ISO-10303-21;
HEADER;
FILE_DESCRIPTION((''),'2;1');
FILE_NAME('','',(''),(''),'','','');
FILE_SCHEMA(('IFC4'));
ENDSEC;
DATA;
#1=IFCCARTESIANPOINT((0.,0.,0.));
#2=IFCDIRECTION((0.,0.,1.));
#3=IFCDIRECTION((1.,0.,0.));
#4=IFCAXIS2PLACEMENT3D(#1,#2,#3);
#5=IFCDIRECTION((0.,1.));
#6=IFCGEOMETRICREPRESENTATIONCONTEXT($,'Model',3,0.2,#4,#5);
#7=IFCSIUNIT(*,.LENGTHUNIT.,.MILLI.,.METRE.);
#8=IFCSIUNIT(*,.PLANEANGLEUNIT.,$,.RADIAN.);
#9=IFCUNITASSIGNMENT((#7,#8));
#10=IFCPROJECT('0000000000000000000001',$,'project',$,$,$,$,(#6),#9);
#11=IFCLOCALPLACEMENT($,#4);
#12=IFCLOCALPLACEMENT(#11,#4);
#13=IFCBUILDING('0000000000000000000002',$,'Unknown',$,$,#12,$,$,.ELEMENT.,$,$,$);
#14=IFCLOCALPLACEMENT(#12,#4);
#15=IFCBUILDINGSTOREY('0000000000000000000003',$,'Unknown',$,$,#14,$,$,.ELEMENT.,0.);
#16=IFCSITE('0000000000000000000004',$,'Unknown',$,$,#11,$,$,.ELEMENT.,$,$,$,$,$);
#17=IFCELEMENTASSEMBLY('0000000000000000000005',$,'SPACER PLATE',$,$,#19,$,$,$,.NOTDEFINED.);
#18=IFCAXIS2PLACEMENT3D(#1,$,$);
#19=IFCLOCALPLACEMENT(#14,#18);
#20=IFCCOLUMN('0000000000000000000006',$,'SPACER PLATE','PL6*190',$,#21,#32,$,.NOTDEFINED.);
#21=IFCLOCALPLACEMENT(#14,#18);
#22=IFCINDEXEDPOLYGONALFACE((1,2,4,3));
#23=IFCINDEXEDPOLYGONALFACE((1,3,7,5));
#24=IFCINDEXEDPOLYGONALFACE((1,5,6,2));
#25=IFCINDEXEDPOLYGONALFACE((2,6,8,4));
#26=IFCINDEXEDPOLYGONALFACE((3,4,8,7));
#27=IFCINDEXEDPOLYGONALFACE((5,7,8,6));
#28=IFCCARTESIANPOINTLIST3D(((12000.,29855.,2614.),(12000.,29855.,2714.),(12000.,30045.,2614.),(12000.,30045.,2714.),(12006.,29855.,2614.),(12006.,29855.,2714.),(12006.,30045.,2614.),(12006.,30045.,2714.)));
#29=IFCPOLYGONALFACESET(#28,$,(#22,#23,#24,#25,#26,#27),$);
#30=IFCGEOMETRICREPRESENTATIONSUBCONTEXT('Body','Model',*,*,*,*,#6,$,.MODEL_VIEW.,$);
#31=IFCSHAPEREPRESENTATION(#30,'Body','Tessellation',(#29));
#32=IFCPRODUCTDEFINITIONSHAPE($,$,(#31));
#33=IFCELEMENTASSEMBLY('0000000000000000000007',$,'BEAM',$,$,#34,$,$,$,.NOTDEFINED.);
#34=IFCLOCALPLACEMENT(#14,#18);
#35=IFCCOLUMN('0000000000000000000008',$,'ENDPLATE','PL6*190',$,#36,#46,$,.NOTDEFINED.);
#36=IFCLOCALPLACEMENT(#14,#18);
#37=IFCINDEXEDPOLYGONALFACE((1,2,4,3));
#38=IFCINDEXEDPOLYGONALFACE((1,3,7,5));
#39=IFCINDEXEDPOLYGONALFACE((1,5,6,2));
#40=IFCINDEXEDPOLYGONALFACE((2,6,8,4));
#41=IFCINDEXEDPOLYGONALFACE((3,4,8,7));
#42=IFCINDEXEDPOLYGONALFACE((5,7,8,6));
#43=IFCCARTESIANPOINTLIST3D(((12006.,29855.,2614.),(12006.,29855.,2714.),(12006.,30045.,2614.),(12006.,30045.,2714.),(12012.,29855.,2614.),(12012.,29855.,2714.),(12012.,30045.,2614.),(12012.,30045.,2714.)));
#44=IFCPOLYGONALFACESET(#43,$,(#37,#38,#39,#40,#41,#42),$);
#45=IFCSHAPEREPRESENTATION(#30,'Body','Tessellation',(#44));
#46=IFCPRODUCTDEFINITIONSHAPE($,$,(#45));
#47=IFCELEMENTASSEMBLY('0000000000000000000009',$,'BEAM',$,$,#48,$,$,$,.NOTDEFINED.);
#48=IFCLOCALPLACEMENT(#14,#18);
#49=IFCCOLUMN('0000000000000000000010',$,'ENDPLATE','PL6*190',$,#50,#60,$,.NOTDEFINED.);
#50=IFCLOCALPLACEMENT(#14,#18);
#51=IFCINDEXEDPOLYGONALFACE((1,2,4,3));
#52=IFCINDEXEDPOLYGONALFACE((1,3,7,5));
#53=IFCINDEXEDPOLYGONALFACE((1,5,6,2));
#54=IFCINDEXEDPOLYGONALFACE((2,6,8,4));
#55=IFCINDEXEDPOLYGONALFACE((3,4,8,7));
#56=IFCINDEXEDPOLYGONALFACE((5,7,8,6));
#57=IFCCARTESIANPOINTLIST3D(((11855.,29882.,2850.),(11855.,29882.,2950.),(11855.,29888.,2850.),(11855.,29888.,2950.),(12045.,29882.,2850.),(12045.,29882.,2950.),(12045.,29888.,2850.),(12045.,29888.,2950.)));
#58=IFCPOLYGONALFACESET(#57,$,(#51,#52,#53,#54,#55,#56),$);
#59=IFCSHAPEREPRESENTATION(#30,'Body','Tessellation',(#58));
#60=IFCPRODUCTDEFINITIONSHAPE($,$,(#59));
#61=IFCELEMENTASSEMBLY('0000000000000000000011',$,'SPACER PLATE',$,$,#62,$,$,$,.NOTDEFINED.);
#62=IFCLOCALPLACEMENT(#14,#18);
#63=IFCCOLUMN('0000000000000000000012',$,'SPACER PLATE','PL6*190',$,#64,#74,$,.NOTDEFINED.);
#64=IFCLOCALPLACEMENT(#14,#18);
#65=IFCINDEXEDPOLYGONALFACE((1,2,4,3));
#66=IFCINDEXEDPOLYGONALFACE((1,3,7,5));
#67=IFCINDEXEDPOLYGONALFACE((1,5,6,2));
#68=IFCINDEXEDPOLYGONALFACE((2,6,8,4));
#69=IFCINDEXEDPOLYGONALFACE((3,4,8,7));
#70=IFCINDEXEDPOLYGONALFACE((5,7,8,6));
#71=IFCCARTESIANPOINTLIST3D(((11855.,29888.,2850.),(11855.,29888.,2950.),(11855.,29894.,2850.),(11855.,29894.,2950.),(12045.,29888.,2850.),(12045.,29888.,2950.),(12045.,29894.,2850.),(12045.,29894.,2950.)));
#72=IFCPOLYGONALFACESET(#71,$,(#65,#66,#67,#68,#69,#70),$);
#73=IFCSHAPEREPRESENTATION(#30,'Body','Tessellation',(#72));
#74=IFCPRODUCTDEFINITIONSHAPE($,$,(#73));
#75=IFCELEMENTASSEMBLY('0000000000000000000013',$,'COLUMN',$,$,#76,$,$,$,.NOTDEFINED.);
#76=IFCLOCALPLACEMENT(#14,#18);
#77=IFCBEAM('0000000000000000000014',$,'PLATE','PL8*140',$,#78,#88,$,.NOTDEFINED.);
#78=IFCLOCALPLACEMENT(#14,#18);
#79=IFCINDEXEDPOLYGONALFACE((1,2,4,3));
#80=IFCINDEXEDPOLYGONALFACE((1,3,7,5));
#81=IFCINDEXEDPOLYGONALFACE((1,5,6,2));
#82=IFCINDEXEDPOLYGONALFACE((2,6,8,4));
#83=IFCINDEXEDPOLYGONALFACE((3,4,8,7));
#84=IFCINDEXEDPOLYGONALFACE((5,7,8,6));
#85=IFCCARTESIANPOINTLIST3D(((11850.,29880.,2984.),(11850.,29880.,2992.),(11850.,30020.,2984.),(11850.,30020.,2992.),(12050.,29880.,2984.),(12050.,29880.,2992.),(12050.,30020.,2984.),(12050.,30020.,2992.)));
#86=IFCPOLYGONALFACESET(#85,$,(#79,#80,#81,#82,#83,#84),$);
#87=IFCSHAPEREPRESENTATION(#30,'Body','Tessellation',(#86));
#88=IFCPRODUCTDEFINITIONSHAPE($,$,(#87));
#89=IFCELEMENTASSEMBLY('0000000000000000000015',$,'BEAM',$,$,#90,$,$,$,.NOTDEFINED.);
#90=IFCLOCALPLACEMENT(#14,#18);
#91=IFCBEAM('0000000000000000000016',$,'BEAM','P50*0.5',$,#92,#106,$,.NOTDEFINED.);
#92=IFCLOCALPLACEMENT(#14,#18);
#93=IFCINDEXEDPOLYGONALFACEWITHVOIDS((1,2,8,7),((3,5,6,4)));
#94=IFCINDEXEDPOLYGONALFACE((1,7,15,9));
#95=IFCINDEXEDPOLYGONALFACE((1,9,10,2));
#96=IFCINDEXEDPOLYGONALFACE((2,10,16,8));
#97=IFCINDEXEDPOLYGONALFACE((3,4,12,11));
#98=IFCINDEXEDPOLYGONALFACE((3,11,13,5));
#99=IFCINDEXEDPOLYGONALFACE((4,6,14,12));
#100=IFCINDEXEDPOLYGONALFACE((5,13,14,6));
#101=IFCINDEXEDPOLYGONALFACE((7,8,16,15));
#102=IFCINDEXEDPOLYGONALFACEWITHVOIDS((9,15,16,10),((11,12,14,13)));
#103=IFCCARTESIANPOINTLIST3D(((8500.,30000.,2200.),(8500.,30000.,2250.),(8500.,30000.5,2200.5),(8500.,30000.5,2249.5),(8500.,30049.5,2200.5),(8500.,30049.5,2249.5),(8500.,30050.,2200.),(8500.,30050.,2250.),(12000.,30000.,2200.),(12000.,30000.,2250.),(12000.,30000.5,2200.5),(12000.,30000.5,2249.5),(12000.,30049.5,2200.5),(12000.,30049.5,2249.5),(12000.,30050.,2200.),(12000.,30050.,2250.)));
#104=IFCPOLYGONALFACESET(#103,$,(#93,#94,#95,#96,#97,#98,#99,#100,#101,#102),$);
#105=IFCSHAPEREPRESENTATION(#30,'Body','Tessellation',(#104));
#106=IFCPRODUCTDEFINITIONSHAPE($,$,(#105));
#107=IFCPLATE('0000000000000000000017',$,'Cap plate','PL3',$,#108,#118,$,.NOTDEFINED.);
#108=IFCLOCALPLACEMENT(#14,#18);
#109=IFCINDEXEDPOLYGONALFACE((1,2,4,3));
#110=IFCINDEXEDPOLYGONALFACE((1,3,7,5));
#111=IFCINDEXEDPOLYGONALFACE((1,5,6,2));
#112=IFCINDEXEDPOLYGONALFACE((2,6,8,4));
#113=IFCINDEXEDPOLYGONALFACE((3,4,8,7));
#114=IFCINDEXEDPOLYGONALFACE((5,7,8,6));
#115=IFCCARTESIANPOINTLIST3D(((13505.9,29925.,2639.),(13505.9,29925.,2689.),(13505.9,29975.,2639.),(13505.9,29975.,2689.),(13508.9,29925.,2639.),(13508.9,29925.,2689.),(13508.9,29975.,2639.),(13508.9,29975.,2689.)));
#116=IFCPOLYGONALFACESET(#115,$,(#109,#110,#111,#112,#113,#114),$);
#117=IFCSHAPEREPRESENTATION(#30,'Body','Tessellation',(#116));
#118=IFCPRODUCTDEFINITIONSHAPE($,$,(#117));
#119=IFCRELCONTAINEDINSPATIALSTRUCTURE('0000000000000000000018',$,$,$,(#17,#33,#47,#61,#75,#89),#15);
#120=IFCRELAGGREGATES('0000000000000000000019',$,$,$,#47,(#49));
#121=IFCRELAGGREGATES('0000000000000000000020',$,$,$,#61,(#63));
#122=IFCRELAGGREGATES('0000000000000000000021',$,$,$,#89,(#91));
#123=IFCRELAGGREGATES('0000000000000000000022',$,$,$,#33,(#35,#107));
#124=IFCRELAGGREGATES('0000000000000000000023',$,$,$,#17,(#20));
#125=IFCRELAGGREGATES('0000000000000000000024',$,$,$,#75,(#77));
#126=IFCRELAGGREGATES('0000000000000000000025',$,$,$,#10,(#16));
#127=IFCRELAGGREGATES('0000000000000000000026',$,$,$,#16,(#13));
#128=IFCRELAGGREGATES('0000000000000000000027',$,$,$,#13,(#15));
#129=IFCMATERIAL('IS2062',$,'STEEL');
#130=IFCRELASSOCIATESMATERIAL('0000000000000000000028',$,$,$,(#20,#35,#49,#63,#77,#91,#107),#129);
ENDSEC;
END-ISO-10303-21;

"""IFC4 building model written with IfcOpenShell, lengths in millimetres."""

from ifc_helpers import new_model, si_unit, direction, frame, origin_with_axes, place, context, subcontext, project, spatial, line, indexed_curve, outline, extrude, material, element, aggregate, save


model = new_model("IFC4")

# Units and contexts
model_context = context("Model", 3, precision=0.2, world=origin_with_axes(), true_north=direction((0.0, 1.0)))
body_context = subcontext(model_context, "Body", "Model", "MODEL_VIEW")
ifc_project = project(units=[si_unit("LENGTHUNIT", "METRE", prefix="MILLI"), si_unit("PLANEANGLEUNIT", "RADIAN")], contexts=[model_context])

# Site, building, storey
site_placement = place(None, origin_with_axes())
site = spatial("IfcSite", under=ifc_project, at=site_placement, Name="Unknown", CompositionType="ELEMENT")
building_placement = place(site_placement, origin_with_axes())
building = spatial("IfcBuilding", under=site, at=building_placement, Name="Unknown", CompositionType="ELEMENT")
storey_placement = place(building_placement, origin_with_axes())
storey = spatial("IfcBuildingStorey", under=building, at=storey_placement, Name="Unknown", CompositionType="ELEMENT", Elevation=0.0)

# Element assemblies, columns
assembly_1_placement = place(storey_placement, frame((12003.0, 29950.0, 2614.0), z_axis=(1.0, 0.0, 0.0), x_axis=(0.0, 0.0, 1.0)))
assembly_1 = element("IfcElementAssembly", 1, at=assembly_1_placement, inside=storey, Name="SPACER PLATE", PredefinedType="NOTDEFINED")
ifc_material_1 = material(Name="IS2062", Category="STEEL")
column_1_placement = place(assembly_1_placement, origin_with_axes())
column_1 = element("IfcColumn", 2, at=column_1_placement, material=ifc_material_1, Name="SPACER PLATE", Description="PL6*190", PredefinedType="NOTDEFINED", context=body_context, shape_type="SolidModel", body=[
    extrude(outline(indexed_curve([(-3.0, -95.0), (3.0, -95.0), (3.0, 95.0), (-3.0, 95.0)], segments=[line(1, 2, 3, 4, 1)])), frame((0.0, 0.0, 0.0), z_axis=(-1.0, 0.0, 0.0), x_axis=(0.0, 0.0, 1.0)), (0.0, 0.0, -1.0), 100.0),
])
assembly_2_placement = place(storey_placement, frame((13505.9, 29950.0, 2664.0), z_axis=(0.0, 1.0, 0.0), x_axis=(-1.0, 0.0, 0.0)))
assembly_2 = element("IfcElementAssembly", 3, at=assembly_2_placement, inside=storey, Name="BEAM", PredefinedType="NOTDEFINED")
column_2_placement = place(assembly_2_placement, frame((1496.9, -50.0, 0.0), z_axis=(-1.0, 0.0, 0.0), x_axis=(0.0, 1.0, 0.0)))
column_2 = element("IfcColumn", 4, at=column_2_placement, material=ifc_material_1, Name="ENDPLATE", Description="PL6*190", PredefinedType="NOTDEFINED", context=body_context, shape_type="SolidModel", body=[
    extrude(outline(indexed_curve([(-3.0, -95.0), (3.0, -95.0), (3.0, 95.0), (-3.0, 95.0)], segments=[line(1, 2, 3, 4, 1)])), frame((0.0, 0.0, 0.0), z_axis=(-1.0, 0.0, 0.0), x_axis=(0.0, 0.0, 1.0)), (0.0, 0.0, -1.0), 100.0),
])
assembly_3_placement = place(storey_placement, frame((11950.0, 30000.0, 2900.0), z_axis=(-1.0, 0.0, 0.0), x_axis=(0.0, -1.0, 0.0)))
assembly_3 = element("IfcElementAssembly", 5, at=assembly_3_placement, inside=storey, Name="BEAM", PredefinedType="NOTDEFINED")
column_3_placement = place(assembly_3_placement, frame((115.0, -50.0, 0.0), z_axis=(1.0, 0.0, 0.0), x_axis=(0.0, 1.0, 0.0)))
column_3 = element("IfcColumn", 6, at=column_3_placement, material=ifc_material_1, Name="ENDPLATE", Description="PL6*190", PredefinedType="NOTDEFINED", context=body_context, shape_type="SolidModel", body=[
    extrude(outline(indexed_curve([(-3.0, -95.0), (3.0, -95.0), (3.0, 95.0), (-3.0, 95.0)], segments=[line(1, 2, 3, 4, 1)])), frame((0.0, 0.0, 0.0), z_axis=(-1.0, 0.0, 0.0), x_axis=(0.0, 0.0, 1.0)), (0.0, 0.0, -1.0), 100.0),
])
aggregate(assembly_3, [column_3])
assembly_4_placement = place(storey_placement, frame((11950.0, 29891.0, 2850.0), z_axis=(0.0, -1.0, 0.0), x_axis=(0.0, 0.0, 1.0)))
assembly_4 = element("IfcElementAssembly", 7, at=assembly_4_placement, inside=storey, Name="SPACER PLATE", PredefinedType="NOTDEFINED")
column_4_placement = place(assembly_4_placement, origin_with_axes())
column_4 = element("IfcColumn", 8, at=column_4_placement, material=ifc_material_1, Name="SPACER PLATE", Description="PL6*190", PredefinedType="NOTDEFINED", context=body_context, shape_type="SolidModel", body=[
    extrude(outline(indexed_curve([(-3.0, -95.0), (3.0, -95.0), (3.0, 95.0), (-3.0, 95.0)], segments=[line(1, 2, 3, 4, 1)])), frame((0.0, 0.0, 0.0), z_axis=(-1.0, 0.0, 0.0), x_axis=(0.0, 0.0, 1.0)), (0.0, 0.0, -1.0), 100.0),
])
aggregate(assembly_4, [column_4])

# Element assemblies, beams
assembly_5_placement = place(storey_placement, frame((11950.0, 29950.0, 0.0), z_axis=(0.0, 1.0, 0.0), x_axis=(0.0, 0.0, 1.0)))
assembly_5 = element("IfcElementAssembly", 9, at=assembly_5_placement, inside=storey, Name="COLUMN", PredefinedType="NOTDEFINED")
beam_1_placement = place(assembly_5_placement, frame((2988.0, 100.0, 0.0), z_axis=(-1.0, 0.0, 0.0), x_axis=(0.0, -1.0, 0.0)))
beam_1 = element("IfcBeam", 10, at=beam_1_placement, material=ifc_material_1, Name="PLATE", Description="PL8*140", PredefinedType="NOTDEFINED", context=body_context, shape_type="SolidModel", body=[
    extrude(outline(indexed_curve([(-4.0, -70.0), (4.0, -70.0), (4.0, 70.0), (-4.0, 70.0)], segments=[line(1, 2, 3, 4, 1)])), frame((0.0, 0.0, 0.0), z_axis=(-1.0, 0.0, 0.0), x_axis=(0.0, 0.0, 1.0)), (0.0, 0.0, -1.0), 200.0),
])
assembly_6_placement = place(storey_placement, frame((12000.0, 30025.0, 2225.0), z_axis=(0.0, 1.0, 0.0), x_axis=(-1.0, 0.0, 0.0)))
assembly_6 = element("IfcElementAssembly", 11, at=assembly_6_placement, inside=storey, Name="BEAM", PredefinedType="NOTDEFINED")
beam_2_placement = place(assembly_6_placement, origin_with_axes())
beam_2 = element("IfcBeam", 12, at=beam_2_placement, material=ifc_material_1, Name="BEAM", Description="P50*0.5", PredefinedType="NOTDEFINED", context=body_context, shape_type="SolidModel", body=[
    extrude(outline(indexed_curve([(-25.0, -25.0), (25.0, -25.0), (25.0, 25.0), (-25.0, 25.0)], segments=[line(1, 2, 3, 4, 1)]), holes=[indexed_curve([(-24.5, -24.5), (-24.5, 24.5), (24.5, 24.5), (24.5, -24.5)], segments=[line(1, 2, 3, 4, 1)])]), frame((0.0, 0.0, 0.0), z_axis=(-1.0, 0.0, 0.0), x_axis=(0.0, 0.0, 1.0)), (0.0, 0.0, -1.0), 3500.0),
])
aggregate(assembly_6, [beam_2])

# Plate
plate_1_placement = place(assembly_2_placement, frame((-1.5, 25.0, 25.0), z_axis=(-1.0, 0.0, 0.0), x_axis=(0.0, 0.0, -1.0)))
plate_1 = element("IfcPlate", 13, at=plate_1_placement, material=ifc_material_1, Name="Cap plate", Description="PL3", PredefinedType="NOTDEFINED", context=body_context, shape_type="SolidModel", body=[
    extrude(outline(indexed_curve([(0.0, 0.0), (50.0, 0.0), (50.0, 50.0), (0.0, 50.0)], segments=[line(1, 2, 3, 4, 1)])), frame((0.0, 0.0, 1.5), z_axis=(0.0, 0.0, 1.0), x_axis=(1.0, 0.0, 0.0)), (0.0, 0.0, -1.0), 3.0),
])
aggregate(assembly_2, [column_2, plate_1])

aggregate(assembly_1, [column_1])
aggregate(assembly_5, [beam_1])

save(model, "model.ifc")
